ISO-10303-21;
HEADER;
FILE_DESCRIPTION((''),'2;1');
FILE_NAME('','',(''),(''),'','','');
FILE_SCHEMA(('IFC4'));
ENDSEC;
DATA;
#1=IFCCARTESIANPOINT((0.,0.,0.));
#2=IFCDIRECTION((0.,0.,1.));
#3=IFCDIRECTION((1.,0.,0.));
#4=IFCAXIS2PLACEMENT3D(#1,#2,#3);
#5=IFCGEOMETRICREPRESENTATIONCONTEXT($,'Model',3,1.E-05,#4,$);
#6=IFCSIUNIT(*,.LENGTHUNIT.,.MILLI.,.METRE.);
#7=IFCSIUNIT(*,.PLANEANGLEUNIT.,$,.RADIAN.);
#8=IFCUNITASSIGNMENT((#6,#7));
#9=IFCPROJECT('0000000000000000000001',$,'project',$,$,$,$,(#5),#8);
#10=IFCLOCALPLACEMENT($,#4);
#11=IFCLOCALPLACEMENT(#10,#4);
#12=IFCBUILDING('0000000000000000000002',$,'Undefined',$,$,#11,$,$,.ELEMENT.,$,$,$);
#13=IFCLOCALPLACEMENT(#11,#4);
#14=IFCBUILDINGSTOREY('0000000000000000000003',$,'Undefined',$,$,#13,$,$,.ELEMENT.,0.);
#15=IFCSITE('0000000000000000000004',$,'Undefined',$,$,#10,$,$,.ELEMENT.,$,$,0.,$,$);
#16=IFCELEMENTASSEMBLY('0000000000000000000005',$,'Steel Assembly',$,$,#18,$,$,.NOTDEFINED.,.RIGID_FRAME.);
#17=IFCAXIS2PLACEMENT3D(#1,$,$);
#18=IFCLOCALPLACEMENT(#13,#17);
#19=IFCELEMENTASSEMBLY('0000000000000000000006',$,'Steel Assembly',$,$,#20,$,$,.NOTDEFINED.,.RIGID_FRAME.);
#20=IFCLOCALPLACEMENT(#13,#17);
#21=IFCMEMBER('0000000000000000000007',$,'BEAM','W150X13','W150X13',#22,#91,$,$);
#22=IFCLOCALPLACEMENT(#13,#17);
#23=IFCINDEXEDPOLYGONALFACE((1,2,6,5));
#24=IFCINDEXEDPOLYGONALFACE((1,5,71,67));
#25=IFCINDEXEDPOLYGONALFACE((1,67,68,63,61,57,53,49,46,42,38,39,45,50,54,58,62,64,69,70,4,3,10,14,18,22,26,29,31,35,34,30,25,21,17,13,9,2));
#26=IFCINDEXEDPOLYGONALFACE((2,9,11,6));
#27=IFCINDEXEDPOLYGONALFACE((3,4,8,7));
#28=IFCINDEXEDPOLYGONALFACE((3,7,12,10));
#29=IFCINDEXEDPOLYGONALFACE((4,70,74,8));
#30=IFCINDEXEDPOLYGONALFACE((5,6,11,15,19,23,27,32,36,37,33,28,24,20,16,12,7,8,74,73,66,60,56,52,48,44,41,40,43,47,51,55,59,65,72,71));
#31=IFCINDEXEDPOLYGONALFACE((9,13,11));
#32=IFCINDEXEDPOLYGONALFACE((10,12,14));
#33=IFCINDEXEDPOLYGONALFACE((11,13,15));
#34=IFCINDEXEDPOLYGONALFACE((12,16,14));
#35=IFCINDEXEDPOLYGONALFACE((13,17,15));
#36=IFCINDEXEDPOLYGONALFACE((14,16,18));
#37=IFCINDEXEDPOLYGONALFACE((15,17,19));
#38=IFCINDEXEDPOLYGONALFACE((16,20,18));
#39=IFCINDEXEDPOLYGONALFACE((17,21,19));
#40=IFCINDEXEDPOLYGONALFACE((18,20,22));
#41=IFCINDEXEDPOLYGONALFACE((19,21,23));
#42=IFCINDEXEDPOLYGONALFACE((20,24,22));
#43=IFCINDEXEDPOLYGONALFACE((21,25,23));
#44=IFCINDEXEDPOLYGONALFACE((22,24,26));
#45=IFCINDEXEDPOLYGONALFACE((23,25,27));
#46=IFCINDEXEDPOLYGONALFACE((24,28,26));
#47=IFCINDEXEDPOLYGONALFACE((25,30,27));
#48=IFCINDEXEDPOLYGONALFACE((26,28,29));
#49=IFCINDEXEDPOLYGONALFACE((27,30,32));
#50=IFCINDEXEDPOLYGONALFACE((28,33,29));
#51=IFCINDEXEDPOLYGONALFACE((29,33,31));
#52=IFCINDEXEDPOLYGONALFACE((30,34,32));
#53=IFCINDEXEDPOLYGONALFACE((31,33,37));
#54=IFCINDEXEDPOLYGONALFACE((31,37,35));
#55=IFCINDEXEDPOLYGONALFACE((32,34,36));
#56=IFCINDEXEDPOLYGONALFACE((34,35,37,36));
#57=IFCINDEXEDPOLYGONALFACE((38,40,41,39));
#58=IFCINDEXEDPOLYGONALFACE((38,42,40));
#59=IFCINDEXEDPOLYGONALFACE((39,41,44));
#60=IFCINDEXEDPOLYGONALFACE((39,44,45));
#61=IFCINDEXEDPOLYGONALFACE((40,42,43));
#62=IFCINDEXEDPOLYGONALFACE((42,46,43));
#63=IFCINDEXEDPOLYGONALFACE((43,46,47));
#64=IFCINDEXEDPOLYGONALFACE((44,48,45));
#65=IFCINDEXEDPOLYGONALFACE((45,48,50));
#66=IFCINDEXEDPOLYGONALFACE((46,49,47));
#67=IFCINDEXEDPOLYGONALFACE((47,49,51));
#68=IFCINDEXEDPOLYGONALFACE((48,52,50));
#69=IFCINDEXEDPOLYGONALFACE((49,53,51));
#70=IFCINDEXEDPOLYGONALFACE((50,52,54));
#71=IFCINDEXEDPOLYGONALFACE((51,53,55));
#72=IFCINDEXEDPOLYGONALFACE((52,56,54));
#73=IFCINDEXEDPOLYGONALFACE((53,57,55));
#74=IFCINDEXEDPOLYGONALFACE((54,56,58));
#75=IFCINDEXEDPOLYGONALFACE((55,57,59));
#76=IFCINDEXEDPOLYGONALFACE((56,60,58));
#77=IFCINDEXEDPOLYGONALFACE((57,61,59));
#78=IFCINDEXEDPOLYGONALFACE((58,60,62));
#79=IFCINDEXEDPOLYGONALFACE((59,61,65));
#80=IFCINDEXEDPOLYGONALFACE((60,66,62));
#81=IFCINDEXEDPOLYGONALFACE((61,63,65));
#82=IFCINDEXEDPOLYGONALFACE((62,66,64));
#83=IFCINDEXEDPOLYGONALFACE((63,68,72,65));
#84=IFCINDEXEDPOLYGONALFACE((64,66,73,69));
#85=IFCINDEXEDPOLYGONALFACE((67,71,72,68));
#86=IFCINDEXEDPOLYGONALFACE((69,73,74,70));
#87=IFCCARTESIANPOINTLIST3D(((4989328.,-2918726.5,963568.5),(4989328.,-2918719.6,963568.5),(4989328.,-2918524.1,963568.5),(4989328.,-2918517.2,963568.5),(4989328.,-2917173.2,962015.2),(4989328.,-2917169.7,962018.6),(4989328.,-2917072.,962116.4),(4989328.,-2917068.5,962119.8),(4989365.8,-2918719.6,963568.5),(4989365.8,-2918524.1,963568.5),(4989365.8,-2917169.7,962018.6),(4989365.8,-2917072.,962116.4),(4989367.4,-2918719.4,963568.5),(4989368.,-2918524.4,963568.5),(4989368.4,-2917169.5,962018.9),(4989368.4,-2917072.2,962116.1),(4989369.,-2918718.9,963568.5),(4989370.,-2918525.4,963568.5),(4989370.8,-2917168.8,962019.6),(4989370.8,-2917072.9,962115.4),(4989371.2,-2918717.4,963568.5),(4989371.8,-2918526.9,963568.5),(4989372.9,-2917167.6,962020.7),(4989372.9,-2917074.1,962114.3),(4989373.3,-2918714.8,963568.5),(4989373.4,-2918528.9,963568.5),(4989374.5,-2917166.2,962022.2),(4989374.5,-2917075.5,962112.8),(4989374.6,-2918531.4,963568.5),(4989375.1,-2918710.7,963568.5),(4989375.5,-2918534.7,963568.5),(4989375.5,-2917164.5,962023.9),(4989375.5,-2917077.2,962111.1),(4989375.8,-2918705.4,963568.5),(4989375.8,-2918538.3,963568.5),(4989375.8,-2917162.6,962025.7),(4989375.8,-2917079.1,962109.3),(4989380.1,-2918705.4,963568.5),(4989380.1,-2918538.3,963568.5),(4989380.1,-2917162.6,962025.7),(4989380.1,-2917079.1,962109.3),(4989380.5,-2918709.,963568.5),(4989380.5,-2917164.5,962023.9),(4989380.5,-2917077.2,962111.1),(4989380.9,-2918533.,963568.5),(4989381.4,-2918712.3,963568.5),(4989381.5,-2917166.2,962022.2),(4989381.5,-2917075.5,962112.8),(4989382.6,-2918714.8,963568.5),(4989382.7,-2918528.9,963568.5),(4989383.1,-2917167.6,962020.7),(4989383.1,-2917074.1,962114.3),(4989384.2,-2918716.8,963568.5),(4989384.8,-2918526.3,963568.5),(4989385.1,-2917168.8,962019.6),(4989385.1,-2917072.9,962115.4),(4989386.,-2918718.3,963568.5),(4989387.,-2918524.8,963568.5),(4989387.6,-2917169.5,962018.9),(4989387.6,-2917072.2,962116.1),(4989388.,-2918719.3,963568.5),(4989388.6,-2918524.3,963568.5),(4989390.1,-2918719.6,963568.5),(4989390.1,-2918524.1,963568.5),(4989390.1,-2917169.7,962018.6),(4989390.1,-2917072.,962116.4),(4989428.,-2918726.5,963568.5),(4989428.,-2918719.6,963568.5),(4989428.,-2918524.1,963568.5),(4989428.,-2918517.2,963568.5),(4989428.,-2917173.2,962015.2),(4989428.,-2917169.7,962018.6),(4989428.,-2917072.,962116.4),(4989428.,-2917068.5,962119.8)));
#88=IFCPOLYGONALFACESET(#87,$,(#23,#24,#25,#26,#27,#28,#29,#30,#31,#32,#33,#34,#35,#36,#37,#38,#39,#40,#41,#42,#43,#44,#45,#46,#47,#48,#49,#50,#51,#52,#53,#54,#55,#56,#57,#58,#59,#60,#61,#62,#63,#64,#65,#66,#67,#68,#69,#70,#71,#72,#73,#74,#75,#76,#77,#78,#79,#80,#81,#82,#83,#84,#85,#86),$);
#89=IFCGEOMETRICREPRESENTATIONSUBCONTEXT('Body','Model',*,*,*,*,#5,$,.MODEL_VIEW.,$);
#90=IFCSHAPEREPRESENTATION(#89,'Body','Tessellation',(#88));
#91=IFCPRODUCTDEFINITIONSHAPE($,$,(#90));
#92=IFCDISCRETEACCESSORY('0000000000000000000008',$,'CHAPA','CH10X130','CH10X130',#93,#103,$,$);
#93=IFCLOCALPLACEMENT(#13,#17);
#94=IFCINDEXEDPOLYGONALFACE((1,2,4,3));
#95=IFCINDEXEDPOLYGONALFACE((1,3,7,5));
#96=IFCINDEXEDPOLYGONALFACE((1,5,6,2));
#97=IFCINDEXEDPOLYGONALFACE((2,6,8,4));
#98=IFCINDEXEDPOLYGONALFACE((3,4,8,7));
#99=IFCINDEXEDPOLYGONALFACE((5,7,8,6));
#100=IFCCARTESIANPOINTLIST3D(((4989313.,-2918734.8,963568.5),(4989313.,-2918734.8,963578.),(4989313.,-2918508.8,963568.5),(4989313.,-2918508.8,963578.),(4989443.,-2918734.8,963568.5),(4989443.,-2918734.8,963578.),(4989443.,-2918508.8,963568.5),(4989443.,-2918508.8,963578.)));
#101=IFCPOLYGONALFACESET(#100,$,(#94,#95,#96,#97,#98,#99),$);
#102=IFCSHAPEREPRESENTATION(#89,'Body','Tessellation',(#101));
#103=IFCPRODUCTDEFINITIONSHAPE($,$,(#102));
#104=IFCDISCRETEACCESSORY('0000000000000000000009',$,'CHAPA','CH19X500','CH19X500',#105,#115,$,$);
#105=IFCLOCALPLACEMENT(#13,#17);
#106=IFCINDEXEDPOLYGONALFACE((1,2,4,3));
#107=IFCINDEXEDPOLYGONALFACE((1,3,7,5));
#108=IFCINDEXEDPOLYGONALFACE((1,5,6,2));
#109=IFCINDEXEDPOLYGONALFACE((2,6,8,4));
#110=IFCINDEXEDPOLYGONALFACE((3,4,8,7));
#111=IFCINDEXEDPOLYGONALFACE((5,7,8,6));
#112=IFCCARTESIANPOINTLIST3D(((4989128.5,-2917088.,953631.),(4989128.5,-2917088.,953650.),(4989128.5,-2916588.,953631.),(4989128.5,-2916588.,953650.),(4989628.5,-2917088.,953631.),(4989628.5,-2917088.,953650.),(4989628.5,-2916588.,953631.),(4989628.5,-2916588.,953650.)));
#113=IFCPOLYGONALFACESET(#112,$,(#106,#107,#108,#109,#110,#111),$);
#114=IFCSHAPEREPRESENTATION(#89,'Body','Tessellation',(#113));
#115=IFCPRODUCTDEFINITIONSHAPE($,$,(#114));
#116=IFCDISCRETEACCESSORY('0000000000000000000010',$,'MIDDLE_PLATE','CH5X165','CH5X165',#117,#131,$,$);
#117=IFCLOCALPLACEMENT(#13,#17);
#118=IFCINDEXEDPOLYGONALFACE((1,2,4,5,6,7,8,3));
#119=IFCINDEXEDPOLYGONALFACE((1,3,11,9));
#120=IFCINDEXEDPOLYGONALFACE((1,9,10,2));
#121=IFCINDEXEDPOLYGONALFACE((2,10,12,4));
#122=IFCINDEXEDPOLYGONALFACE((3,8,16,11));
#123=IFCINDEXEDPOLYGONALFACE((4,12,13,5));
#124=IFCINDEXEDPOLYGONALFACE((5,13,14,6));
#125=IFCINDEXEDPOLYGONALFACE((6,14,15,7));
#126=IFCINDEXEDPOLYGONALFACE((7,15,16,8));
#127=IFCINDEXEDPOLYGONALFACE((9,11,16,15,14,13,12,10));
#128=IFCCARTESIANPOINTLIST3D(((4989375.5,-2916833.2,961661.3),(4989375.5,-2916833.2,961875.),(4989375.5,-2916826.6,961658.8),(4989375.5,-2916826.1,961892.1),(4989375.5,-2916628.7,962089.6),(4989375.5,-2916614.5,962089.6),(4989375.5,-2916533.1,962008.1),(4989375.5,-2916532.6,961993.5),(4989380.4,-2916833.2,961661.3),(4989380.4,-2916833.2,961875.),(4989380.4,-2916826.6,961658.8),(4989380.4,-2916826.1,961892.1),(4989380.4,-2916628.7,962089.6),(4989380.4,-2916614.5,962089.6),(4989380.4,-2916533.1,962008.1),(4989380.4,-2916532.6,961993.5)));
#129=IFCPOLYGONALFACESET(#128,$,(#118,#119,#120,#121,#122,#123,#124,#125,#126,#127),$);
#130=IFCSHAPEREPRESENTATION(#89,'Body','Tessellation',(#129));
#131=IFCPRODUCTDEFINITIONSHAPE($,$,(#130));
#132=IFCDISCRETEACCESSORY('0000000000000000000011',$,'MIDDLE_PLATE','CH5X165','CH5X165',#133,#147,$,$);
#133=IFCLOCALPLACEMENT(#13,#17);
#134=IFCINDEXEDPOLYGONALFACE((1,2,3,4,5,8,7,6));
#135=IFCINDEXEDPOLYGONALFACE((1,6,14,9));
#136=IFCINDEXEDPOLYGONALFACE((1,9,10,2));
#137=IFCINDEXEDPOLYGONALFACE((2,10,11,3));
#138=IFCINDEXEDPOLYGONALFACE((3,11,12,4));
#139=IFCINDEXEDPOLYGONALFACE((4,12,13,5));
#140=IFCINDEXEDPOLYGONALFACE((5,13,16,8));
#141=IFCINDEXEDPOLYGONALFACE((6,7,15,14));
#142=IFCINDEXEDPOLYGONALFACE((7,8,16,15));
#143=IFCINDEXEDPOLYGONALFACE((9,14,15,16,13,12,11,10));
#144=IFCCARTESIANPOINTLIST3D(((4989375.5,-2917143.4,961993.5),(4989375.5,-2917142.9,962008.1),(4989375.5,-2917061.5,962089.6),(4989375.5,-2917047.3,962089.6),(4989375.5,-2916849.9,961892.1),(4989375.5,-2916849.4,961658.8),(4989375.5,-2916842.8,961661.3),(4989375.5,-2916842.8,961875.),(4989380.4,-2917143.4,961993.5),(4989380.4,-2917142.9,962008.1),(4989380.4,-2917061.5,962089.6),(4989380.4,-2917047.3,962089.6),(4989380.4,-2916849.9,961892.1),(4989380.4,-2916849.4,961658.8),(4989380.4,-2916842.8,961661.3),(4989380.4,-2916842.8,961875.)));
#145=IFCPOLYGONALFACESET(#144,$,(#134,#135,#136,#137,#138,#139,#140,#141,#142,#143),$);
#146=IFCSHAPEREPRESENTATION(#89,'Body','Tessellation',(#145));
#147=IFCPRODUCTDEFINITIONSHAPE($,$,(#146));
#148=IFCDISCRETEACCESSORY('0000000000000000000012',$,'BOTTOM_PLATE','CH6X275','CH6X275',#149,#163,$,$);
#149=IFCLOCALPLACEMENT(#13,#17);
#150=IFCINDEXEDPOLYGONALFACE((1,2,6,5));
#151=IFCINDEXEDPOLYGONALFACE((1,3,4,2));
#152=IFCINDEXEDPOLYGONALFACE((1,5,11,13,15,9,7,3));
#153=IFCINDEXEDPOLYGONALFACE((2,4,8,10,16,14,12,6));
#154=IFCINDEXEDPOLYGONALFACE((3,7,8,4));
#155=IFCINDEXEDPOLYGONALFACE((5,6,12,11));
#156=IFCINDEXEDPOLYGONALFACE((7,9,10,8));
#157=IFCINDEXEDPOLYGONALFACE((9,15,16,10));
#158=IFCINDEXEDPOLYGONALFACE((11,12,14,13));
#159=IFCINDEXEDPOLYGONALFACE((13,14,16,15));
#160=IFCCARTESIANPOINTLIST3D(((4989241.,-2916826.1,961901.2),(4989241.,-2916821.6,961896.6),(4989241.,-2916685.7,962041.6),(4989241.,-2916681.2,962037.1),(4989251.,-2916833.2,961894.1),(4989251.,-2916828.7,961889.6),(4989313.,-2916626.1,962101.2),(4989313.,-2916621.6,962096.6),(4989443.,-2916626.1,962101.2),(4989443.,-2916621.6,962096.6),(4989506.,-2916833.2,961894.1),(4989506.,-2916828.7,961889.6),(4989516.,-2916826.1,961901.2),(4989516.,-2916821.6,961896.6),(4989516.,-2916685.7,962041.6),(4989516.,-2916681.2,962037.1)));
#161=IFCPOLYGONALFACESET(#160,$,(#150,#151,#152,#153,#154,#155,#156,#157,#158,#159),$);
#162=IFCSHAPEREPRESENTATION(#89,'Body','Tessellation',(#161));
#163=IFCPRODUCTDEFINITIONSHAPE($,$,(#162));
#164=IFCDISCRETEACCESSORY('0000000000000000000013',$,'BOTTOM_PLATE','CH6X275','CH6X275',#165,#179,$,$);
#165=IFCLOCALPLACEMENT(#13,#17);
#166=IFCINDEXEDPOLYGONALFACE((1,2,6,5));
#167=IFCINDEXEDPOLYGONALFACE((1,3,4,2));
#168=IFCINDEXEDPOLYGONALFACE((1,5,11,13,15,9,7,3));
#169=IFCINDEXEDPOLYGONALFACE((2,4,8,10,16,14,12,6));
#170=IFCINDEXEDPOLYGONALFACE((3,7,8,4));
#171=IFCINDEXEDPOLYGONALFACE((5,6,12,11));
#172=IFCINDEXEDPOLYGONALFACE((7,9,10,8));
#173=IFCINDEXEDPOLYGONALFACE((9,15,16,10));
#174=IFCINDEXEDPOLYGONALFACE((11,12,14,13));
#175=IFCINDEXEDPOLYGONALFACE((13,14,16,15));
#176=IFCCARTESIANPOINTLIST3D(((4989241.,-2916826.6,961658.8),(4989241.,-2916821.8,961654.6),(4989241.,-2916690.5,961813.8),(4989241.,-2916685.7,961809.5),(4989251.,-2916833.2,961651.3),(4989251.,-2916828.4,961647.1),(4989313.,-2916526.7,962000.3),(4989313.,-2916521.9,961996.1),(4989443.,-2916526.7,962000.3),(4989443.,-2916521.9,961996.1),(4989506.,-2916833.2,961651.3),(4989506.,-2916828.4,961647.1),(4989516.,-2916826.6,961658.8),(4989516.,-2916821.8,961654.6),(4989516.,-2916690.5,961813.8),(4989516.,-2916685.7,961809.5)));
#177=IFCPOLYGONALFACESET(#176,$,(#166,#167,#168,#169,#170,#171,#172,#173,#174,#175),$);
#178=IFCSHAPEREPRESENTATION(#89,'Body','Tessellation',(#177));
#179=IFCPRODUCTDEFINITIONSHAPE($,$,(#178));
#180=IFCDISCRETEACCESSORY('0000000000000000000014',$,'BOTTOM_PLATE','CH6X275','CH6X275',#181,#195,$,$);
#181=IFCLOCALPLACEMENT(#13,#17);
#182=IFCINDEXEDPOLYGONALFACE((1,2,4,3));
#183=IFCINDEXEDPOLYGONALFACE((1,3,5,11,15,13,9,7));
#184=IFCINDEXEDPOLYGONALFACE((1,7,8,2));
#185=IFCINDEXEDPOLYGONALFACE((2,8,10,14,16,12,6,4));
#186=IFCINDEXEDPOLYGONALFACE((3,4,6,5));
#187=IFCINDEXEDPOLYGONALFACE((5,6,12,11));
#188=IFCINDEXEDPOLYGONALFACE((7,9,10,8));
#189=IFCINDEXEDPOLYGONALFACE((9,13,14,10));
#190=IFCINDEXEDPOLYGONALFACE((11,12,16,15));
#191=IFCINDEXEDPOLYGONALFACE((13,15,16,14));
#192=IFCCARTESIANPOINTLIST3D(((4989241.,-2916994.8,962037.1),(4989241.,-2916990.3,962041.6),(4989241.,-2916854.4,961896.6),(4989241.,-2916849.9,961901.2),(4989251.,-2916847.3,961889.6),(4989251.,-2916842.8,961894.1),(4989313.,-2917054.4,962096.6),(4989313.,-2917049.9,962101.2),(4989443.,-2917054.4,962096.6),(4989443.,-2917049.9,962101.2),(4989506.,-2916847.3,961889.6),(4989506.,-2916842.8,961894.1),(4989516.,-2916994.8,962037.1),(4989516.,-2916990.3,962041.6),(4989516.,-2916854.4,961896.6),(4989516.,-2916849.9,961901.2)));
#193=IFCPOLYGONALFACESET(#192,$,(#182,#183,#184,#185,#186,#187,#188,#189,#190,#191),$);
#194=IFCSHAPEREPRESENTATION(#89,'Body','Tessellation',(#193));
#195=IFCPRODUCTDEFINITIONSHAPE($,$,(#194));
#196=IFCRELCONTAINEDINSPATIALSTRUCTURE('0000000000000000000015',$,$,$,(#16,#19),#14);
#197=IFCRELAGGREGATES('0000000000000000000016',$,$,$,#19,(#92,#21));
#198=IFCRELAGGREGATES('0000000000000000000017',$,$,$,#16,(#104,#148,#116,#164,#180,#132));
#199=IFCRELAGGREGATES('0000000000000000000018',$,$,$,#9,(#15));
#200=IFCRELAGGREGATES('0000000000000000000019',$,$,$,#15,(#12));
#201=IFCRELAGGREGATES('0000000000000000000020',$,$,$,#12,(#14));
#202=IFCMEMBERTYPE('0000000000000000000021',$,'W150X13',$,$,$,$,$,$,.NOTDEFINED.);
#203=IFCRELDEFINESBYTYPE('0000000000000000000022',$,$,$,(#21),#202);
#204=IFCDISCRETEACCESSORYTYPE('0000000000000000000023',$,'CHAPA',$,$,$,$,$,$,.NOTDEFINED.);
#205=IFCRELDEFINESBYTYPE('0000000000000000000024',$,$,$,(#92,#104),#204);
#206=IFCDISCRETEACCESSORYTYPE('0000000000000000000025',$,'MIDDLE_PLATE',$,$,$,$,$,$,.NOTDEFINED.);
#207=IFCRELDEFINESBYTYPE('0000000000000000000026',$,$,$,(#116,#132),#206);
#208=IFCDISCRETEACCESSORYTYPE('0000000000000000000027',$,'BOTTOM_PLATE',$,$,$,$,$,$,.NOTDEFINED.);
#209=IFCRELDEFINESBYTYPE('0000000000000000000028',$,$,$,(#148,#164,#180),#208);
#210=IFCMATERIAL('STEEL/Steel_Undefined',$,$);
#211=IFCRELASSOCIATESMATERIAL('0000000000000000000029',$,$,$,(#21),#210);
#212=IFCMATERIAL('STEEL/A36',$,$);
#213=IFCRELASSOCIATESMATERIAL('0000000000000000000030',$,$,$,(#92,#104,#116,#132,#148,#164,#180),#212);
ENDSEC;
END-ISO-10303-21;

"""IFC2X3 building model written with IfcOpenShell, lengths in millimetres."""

from ifc_helpers import new_model, si_unit, frame, origin_with_axes, origin_2d_with_axis, place, context, subcontext, project, spatial, polyline, i_section, outline, extrude, clip, halfspace, material, type_object, element, aggregate, save


model = new_model("IFC2X3")

# Units and contexts
model_context = context("Model", 3, precision=1e-05, world=origin_with_axes())
body_context = subcontext(model_context, "Body", "Model", "MODEL_VIEW")
ifc_project = project(units=[si_unit("LENGTHUNIT", "METRE", prefix="MILLI"), si_unit("PLANEANGLEUNIT", "RADIAN")], contexts=[model_context])

# Site, building, storey
site_placement = place(None, origin_with_axes())
site = spatial("IfcSite", under=ifc_project, at=site_placement, Name="Undefined", CompositionType="ELEMENT", RefElevation=0.0)
building_placement = place(site_placement, origin_with_axes())
building = spatial("IfcBuilding", under=site, at=building_placement, Name="Undefined", CompositionType="ELEMENT")
storey_placement = place(building_placement, origin_with_axes())
storey = spatial("IfcBuildingStorey", under=building, at=storey_placement, Name="Undefined", CompositionType="ELEMENT", Elevation=0.0)

# Element assembly
assembly_1_placement = place(storey_placement, origin_with_axes())
assembly_1 = element("IfcElementAssembly", 1, at=assembly_1_placement, inside=storey, Name="Steel Assembly", AssemblyPlace="NOTDEFINED", PredefinedType="RIGID_FRAME")

# Element assembly, member, discrete accessory
assembly_2_placement = place(storey_placement, origin_with_axes())
assembly_2 = element("IfcElementAssembly", 2, at=assembly_2_placement, inside=storey, Name="Steel Assembly", AssemblyPlace="NOTDEFINED", PredefinedType="RIGID_FRAME")
ifc_material_1 = material(Name="STEEL/Steel_Undefined")
member_type = type_object("IfcMemberType", Name="W150X13", PredefinedType="NOTDEFINED")
member_placement = place(assembly_2_placement, frame((4989378.0, -2916767.9, 961714.5), z_axis=(0.0, -0.707107, -0.707107), x_axis=(0.0, -0.707107, 0.707107)))
member = element("IfcMember", 3, at=member_placement, type_object=member_type, material=ifc_material_1, Name="BEAM", Description="W150X13", ObjectType="W150X13", context=body_context, shape_type="Clipping", body=[
    clip(clip(clip(extrude(i_section(OverallWidth=100.0, OverallDepth=148.0, WebThickness=4.3, FlangeThickness=4.9, FilletRadius=10.0, at=origin_2d_with_axis()), frame((2771.4, 0.0, 0.0), z_axis=(-1.0, 0.0, 0.0), x_axis=(0.0, -1.0, 0.0)), (0.0, 0.0, 1.0), 2771.4), halfspace(frame((2548.6, -50.0, -74.0), z_axis=(0.707107, 0.0, -0.707107), x_axis=(0.707107, 0.0, 0.707107)), False)), halfspace(frame((499.2, 50.0, -74.0), z_axis=(-1.0, 0.0, 0.0), x_axis=(0.0, 0.0, 1.0)), False)), halfspace(frame((2547.9, 0.0, -74.0), z_axis=(-0.707107, 0.0, 0.707107), x_axis=(0.0, 1.0, 0.0)), True)),
])
ifc_material_2 = material(Name="STEEL/A36")
discrete_accessory_type_1 = type_object("IfcDiscreteAccessoryType", Name="CHAPA")
discrete_accessory_1_placement = place(assembly_2_placement, frame((4989378.0, -2918508.8, 963573.3), z_axis=(0.0, 0.0, -1.0), x_axis=(0.0, -1.0, 0.0)))
discrete_accessory_1 = element("IfcDiscreteAccessory", 4, at=discrete_accessory_1_placement, type_object=discrete_accessory_type_1, material=ifc_material_2, Name="CHAPA", Description="CH10X130", ObjectType="CH10X130", context=body_context, shape_type="SweptSolid", body=[
    extrude(outline(polyline([(226.0, 65.0), (226.0, -65.0), (0.0, -65.0), (0.0, 65.0), (226.0, 65.0)])), frame((0.0, 0.0, -4.8), z_axis=(0.0, 0.0, 1.0), x_axis=(1.0, 0.0, 0.0)), (0.0, 0.0, 1.0), 9.5),
])

# Discrete accessories
discrete_accessory_2_placement = place(assembly_1_placement, frame((4989628.5, -2916838.0, 953640.5), z_axis=(0.0, 0.0, 1.0), x_axis=(-1.0, 0.0, 0.0)))
discrete_accessory_2 = element("IfcDiscreteAccessory", 5, at=discrete_accessory_2_placement, type_object=discrete_accessory_type_1, material=ifc_material_2, Name="CHAPA", Description="CH19X500", ObjectType="CH19X500", context=body_context, shape_type="SweptSolid", body=[
    extrude(outline(polyline([(500.0, 250.0), (500.0, -250.0), (0.0, -250.0), (0.0, 250.0), (500.0, 250.0)])), frame((0.0, 0.0, -9.5), z_axis=(0.0, 0.0, 1.0), x_axis=(1.0, 0.0, 0.0)), (0.0, 0.0, 1.0), 19.0),
])
discrete_accessory_type_2 = type_object("IfcDiscreteAccessoryType", Name="MIDDLE_PLATE")
discrete_accessory_3_placement = place(assembly_1_placement, frame((4989378.0, -2916621.6, 962096.6), z_axis=(1.0, 0.0, 0.0), x_axis=(0.0, -0.707107, -0.707107)))
discrete_accessory_3 = element("IfcDiscreteAccessory", 6, at=discrete_accessory_3_placement, type_object=discrete_accessory_type_2, material=ifc_material_2, Name="MIDDLE_PLATE", Description="CH5X165", ObjectType="CH5X165", context=body_context, shape_type="SweptSolid", body=[
    extrude(outline(polyline([(0.0, 10.0), (10.0, 0.0), (289.2, 0.0), (306.3, 7.1), (457.4, 158.2), (454.5, 164.6), (10.0, 135.9), (0.0, 125.3), (0.0, 10.0)])), frame((0.0, 0.0, -2.5), z_axis=(0.0, 0.0, 1.0), x_axis=(1.0, 0.0, 0.0)), (0.0, 0.0, 1.0), 4.9),
])
discrete_accessory_4_placement = place(assembly_1_placement, frame((4989378.0, -2917054.4, 962096.6), z_axis=(-1.0, 0.0, 0.0), x_axis=(0.0, 0.707107, -0.707107)))
discrete_accessory_4 = element("IfcDiscreteAccessory", 7, at=discrete_accessory_4_placement, type_object=discrete_accessory_type_2, material=ifc_material_2, Name="MIDDLE_PLATE", Description="CH5X165", ObjectType="CH5X165", context=body_context, shape_type="SweptSolid", body=[
    extrude(outline(polyline([(0.0, 10.0), (10.0, 0.0), (289.2, 0.0), (306.3, 7.1), (457.4, 158.2), (454.5, 164.6), (10.0, 135.9), (0.0, 125.3), (0.0, 10.0)])), frame((0.0, 0.0, -2.5), z_axis=(0.0, 0.0, 1.0), x_axis=(1.0, 0.0, 0.0)), (0.0, 0.0, 1.0), 4.9),
])
discrete_accessory_type_3 = type_object("IfcDiscreteAccessoryType", Name="BOTTOM_PLATE")
discrete_accessory_5_placement = place(assembly_1_placement, frame((4989516.0, -2916683.4, 962039.3), z_axis=(0.0, 0.707107, -0.707107), x_axis=(0.0, -0.707107, -0.707107)))
discrete_accessory_5 = element("IfcDiscreteAccessory", 8, at=discrete_accessory_5_placement, type_object=discrete_accessory_type_3, material=ifc_material_2, Name="BOTTOM_PLATE", Description="CH6X275", ObjectType="CH6X275", context=body_context, shape_type="SweptSolid", body=[
    extrude(outline(polyline([(0.0, 0.0), (198.6, 0.0), (208.6, 10.0), (208.6, 265.0), (198.6, 275.0), (0.0, 275.0), (-84.2, 203.0), (-84.2, 73.0), (0.0, 0.0)])), frame((0.0, 0.0, -3.2), z_axis=(0.0, 0.0, 1.0), x_axis=(1.0, 0.0, 0.0)), (0.0, 0.0, 1.0), 6.4),
])
discrete_accessory_6_placement = place(assembly_1_placement, frame((4989516.0, -2916688.1, 961811.6), z_axis=(0.0, 0.75135, -0.659903), x_axis=(0.0, -0.659903, -0.75135)))
discrete_accessory_6 = element("IfcDiscreteAccessory", 9, at=discrete_accessory_6_placement, type_object=discrete_accessory_type_3, material=ifc_material_2, Name="BOTTOM_PLATE", Description="CH6X275", ObjectType="CH6X275", context=body_context, shape_type="SweptSolid", body=[
    extrude(outline(polyline([(0.0, 0.0), (206.2, 0.0), (216.2, 10.0), (216.2, 265.0), (206.2, 275.0), (0.0, 275.0), (-248.3, 203.0), (-248.3, 73.0), (0.0, 0.0)])), frame((0.0, 0.0, -3.2), z_axis=(0.0, 0.0, 1.0), x_axis=(1.0, 0.0, 0.0)), (0.0, 0.0, 1.0), 6.4),
])
discrete_accessory_7_placement = place(assembly_1_placement, frame((4989516.0, -2916992.6, 962039.3), z_axis=(0.0, 0.707107, 0.707107), x_axis=(0.0, 0.707107, -0.707107)))
discrete_accessory_7 = element("IfcDiscreteAccessory", 10, at=discrete_accessory_7_placement, type_object=discrete_accessory_type_3, material=ifc_material_2, Name="BOTTOM_PLATE", Description="CH6X275", ObjectType="CH6X275", context=body_context, shape_type="SweptSolid", body=[
    extrude(outline(polyline([(0.0, 0.0), (198.6, 0.0), (208.6, 10.0), (208.6, 265.0), (198.6, 275.0), (0.0, 275.0), (-84.2, 203.0), (-84.2, 73.0), (0.0, 0.0)])), frame((0.0, 0.0, -3.2), z_axis=(0.0, 0.0, 1.0), x_axis=(1.0, 0.0, 0.0)), (0.0, 0.0, 1.0), 6.4),
])

aggregate(assembly_2, [discrete_accessory_1, member])
aggregate(assembly_1, [discrete_accessory_2, discrete_accessory_5, discrete_accessory_3, discrete_accessory_6, discrete_accessory_7, discrete_accessory_4])

save(model, "model.ifc")
